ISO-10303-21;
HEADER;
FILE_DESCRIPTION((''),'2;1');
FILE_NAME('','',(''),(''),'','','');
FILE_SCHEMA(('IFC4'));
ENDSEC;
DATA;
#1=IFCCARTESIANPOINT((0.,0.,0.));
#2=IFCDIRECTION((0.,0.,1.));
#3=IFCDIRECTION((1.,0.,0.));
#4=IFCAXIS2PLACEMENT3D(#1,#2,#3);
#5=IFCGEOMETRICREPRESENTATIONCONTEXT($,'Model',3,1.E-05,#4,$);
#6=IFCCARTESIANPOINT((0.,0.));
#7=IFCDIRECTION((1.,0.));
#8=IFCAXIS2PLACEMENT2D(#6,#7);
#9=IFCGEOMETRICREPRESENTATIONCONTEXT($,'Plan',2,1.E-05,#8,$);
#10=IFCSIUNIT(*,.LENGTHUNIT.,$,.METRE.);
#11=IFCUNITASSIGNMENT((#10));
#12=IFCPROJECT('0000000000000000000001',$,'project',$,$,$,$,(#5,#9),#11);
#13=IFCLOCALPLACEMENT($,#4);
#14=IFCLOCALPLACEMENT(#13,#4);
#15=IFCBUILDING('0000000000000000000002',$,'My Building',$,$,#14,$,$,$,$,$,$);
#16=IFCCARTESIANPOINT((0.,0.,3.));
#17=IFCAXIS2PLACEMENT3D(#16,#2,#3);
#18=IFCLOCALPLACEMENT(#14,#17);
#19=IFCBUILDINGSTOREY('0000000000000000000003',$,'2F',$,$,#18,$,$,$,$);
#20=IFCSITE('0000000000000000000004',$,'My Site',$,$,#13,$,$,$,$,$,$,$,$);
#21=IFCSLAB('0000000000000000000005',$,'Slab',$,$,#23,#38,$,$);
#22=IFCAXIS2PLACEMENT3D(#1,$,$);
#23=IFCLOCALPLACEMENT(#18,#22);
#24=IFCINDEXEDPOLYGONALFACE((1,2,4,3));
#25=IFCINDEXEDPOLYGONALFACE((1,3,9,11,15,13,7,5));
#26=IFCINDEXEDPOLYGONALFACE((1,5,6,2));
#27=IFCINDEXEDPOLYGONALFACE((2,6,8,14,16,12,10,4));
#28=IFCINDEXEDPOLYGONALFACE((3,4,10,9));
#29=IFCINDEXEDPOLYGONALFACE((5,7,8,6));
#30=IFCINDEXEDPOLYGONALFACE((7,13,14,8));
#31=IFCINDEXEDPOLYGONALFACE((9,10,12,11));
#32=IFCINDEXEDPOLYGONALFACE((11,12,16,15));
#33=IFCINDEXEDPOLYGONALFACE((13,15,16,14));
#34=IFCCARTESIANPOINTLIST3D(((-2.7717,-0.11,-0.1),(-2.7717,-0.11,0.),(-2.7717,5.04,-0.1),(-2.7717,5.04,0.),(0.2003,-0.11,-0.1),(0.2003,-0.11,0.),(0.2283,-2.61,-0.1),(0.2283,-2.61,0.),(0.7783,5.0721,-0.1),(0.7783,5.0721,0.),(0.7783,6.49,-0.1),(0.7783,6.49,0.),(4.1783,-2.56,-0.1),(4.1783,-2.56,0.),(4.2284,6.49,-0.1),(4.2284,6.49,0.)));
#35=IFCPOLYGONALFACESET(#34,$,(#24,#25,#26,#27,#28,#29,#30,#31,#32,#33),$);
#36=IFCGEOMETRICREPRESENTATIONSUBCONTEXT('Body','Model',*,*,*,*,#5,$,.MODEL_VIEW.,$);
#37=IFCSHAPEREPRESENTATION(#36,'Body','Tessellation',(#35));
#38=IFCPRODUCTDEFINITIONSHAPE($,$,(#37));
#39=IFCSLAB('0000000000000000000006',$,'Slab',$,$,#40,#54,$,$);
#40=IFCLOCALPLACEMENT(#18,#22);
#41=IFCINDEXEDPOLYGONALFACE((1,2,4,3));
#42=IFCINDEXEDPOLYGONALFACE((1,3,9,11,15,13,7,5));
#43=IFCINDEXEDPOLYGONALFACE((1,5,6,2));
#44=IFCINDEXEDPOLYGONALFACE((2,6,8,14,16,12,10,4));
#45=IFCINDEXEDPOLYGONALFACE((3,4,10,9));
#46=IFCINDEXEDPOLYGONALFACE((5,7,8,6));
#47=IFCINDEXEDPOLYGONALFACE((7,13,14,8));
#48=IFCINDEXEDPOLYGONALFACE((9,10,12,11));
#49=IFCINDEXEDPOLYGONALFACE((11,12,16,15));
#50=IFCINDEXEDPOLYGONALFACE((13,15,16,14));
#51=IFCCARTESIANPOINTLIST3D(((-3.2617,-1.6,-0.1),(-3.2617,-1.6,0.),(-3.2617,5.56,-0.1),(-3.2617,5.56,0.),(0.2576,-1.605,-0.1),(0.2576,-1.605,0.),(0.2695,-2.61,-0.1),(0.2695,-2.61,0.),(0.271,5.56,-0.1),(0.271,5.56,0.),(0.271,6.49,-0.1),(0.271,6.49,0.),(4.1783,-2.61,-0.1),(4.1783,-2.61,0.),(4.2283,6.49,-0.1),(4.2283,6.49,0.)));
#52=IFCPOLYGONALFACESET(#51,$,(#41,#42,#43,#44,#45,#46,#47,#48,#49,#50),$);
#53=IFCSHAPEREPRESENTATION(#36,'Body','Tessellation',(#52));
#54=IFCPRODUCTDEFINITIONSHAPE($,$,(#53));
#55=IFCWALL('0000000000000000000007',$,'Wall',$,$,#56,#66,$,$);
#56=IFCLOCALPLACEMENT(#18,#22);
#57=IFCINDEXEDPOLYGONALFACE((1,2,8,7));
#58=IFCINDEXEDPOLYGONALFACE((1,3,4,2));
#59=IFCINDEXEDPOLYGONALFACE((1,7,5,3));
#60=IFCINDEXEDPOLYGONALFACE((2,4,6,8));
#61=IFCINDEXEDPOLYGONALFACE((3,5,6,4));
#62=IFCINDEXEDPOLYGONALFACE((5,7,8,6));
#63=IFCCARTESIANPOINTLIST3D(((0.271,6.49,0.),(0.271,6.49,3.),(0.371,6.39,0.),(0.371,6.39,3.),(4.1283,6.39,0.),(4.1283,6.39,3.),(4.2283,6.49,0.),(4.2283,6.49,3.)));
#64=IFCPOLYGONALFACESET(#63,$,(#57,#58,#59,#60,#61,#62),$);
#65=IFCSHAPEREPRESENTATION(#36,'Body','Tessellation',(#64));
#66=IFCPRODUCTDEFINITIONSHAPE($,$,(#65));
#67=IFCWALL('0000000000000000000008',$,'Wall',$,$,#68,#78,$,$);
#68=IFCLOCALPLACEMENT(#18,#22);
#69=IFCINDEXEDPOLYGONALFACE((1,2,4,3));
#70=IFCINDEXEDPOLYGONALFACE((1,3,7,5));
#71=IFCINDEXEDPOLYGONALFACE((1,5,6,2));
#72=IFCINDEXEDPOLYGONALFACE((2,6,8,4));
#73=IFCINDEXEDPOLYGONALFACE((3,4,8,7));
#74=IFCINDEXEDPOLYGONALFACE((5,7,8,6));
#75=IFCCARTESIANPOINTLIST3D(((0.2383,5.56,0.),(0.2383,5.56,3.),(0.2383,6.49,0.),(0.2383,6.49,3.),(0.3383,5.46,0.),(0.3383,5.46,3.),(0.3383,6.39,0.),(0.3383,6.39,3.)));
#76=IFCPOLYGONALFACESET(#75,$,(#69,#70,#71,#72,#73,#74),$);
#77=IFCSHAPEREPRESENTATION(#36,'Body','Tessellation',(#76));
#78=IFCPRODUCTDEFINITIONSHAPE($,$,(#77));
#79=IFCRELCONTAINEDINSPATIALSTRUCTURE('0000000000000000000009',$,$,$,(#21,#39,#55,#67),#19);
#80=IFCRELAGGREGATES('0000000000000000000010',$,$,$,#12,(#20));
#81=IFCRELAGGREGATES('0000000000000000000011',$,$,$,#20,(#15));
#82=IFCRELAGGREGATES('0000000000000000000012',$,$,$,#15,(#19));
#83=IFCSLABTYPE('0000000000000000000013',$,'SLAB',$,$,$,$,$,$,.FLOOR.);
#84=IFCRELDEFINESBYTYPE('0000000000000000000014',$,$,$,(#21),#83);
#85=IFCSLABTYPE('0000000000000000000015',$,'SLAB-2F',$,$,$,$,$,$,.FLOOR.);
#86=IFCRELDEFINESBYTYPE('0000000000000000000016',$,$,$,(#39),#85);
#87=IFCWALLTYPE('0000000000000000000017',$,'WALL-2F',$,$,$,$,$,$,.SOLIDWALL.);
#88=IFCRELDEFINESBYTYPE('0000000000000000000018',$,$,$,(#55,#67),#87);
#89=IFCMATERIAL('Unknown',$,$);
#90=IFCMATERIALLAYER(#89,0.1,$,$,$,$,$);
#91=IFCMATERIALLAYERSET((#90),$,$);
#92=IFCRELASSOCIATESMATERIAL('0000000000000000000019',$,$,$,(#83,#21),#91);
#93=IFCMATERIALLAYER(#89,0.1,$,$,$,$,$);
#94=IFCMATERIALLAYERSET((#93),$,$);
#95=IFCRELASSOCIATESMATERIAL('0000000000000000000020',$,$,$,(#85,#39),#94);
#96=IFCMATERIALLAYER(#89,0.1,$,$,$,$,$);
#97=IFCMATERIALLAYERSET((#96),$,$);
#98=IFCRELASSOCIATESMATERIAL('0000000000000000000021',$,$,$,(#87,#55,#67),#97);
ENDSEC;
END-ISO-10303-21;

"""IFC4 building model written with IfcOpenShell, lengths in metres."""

from ifc_helpers import new_model, si_unit, frame, origin_with_axes, origin_2d_with_axis, place, context, subcontext, project, spatial, line, indexed_curve, outline, extrude, material, layer, layer_set, layer_usage, type_object, element, save


model = new_model("IFC4")

# Units and contexts
model_context = context("Model", 3, precision=1e-05, world=origin_with_axes())
plan_context = context("Plan", 2, precision=1e-05, world=origin_2d_with_axis())
body_context_1 = subcontext(model_context, "Body", "Model", "MODEL_VIEW")
ifc_project = project(units=[si_unit("LENGTHUNIT", "METRE")], contexts=[model_context, plan_context])

# Site, building, storey
site_placement = place(None, origin_with_axes())
site = spatial("IfcSite", under=ifc_project, at=site_placement, Name="My Site")
building_placement = place(site_placement, origin_with_axes())
building = spatial("IfcBuilding", under=site, at=building_placement, Name="My Building")
storey_placement = place(building_placement, frame((0.0, 0.0, 3.0), z_axis=(0.0, 0.0, 1.0), x_axis=(1.0, 0.0, 0.0)))
storey = spatial("IfcBuildingStorey", under=building, at=storey_placement, Name="2F")

# Slabs
ifc_material = material(Name="Unknown")
ifc_layer_1 = layer(ifc_material, 0.1)
ifc_layer_set_1 = layer_set([ifc_layer_1])
ifc_layer_usage_1 = layer_usage(ifc_layer_set_1, "AXIS3", "POSITIVE", -0.1)
slab_type_1 = type_object("IfcSlabType", Name="SLAB", PredefinedType="FLOOR", material=ifc_layer_set_1)
slab_1_placement = place(storey_placement, frame((4.2284, 6.49, 0.0), z_axis=(0.0, 0.0, 1.0), x_axis=(1.0, 0.0, 0.0)))
element("IfcSlab", 1, at=slab_1_placement, inside=storey, type_object=slab_type_1, material=ifc_layer_usage_1, Name="Slab", context=body_context_1, shape_type="SweptSolid", body=[
    extrude(outline(indexed_curve([(0.0, 0.0), (-3.45, 0.0), (-3.45, -1.4179), (-7.0, -1.45), (-7.0, -6.6), (-4.028, -6.6), (-4.0, -9.1), (-0.05, -9.05), (0.0, 0.0)])), frame((0.0, 0.0, -0.1), z_axis=(0.0, 0.0, 1.0), x_axis=(1.0, 0.0, 0.0)), (0.0, 0.0, 1.0), 0.1),
])
ifc_layer_2 = layer(ifc_material, 0.1)
ifc_layer_set_2 = layer_set([ifc_layer_2])
ifc_layer_usage_2 = layer_usage(ifc_layer_set_2, "AXIS3", "POSITIVE", -0.1)
slab_type_2 = type_object("IfcSlabType", Name="SLAB-2F", PredefinedType="FLOOR", material=ifc_layer_set_2)
slab_2_placement = place(storey_placement, frame((4.2283, 6.49, 0.0), z_axis=(0.0, 0.0, 1.0), x_axis=(1.0, 0.0, 0.0)))
element("IfcSlab", 2, at=slab_2_placement, inside=storey, type_object=slab_type_2, material=ifc_layer_usage_2, Name="Slab", context=body_context_1, shape_type="SweptSolid", body=[
    extrude(outline(indexed_curve([(0.0, 0.0), (-3.9573, 0.0), (-3.9573, -0.93), (-7.49, -0.93), (-7.49, -8.09), (-3.9708, -8.0949), (-3.9589, -9.1), (-0.05, -9.1), (0.0, 0.0)])), frame((0.0, 0.0, -0.1), z_axis=(0.0, 0.0, 1.0), x_axis=(1.0, 0.0, 0.0)), (0.0, 0.0, 1.0), 0.1),
])

# Walls
ifc_layer_3 = layer(ifc_material, 0.1)
ifc_layer_set_3 = layer_set([ifc_layer_3])
ifc_layer_usage_3 = layer_usage(ifc_layer_set_3, "AXIS2", "POSITIVE", 0.0)
wall_type = type_object("IfcWallType", Name="WALL-2F", PredefinedType="SOLIDWALL", material=ifc_layer_set_3)
wall_1_placement = place(storey_placement, frame((4.2283, 6.49, 0.0), z_axis=(0.0, 0.0, 1.0), x_axis=(-1.0, 0.0, 0.0)))
element("IfcWall", 3, at=wall_1_placement, inside=storey, type_object=wall_type, material=ifc_layer_usage_3, Name="Wall", context=body_context_1, shape_type="SweptSolid", body=[
    extrude(outline(indexed_curve([(0.0, 0.0), (0.1, 0.1), (3.8573, 0.1), (3.9573, 0.0)], segments=[line(1, 2, 3, 4, 1)])), origin_with_axes(), (0.0, 0.0, 1.0), 3.0),
])
ifc_layer_usage_4 = layer_usage(ifc_layer_set_3, "AXIS2", "POSITIVE", 0.0)
wall_2_placement = place(storey_placement, frame((0.2383, 6.49, 0.0), z_axis=(0.0, 0.0, 1.0), x_axis=(0.0, -1.0, 0.0)))
element("IfcWall", 4, at=wall_2_placement, inside=storey, type_object=wall_type, material=ifc_layer_usage_4, Name="Wall", context=body_context_1, shape_type="SweptSolid", body=[
    extrude(outline(indexed_curve([(0.0, 0.0), (0.1, 0.1), (1.03, 0.1), (0.93, 0.0)], segments=[line(1, 2, 3, 4, 1)])), origin_with_axes(), (0.0, 0.0, 1.0), 3.0),
])

save(model, "model.ifc")
